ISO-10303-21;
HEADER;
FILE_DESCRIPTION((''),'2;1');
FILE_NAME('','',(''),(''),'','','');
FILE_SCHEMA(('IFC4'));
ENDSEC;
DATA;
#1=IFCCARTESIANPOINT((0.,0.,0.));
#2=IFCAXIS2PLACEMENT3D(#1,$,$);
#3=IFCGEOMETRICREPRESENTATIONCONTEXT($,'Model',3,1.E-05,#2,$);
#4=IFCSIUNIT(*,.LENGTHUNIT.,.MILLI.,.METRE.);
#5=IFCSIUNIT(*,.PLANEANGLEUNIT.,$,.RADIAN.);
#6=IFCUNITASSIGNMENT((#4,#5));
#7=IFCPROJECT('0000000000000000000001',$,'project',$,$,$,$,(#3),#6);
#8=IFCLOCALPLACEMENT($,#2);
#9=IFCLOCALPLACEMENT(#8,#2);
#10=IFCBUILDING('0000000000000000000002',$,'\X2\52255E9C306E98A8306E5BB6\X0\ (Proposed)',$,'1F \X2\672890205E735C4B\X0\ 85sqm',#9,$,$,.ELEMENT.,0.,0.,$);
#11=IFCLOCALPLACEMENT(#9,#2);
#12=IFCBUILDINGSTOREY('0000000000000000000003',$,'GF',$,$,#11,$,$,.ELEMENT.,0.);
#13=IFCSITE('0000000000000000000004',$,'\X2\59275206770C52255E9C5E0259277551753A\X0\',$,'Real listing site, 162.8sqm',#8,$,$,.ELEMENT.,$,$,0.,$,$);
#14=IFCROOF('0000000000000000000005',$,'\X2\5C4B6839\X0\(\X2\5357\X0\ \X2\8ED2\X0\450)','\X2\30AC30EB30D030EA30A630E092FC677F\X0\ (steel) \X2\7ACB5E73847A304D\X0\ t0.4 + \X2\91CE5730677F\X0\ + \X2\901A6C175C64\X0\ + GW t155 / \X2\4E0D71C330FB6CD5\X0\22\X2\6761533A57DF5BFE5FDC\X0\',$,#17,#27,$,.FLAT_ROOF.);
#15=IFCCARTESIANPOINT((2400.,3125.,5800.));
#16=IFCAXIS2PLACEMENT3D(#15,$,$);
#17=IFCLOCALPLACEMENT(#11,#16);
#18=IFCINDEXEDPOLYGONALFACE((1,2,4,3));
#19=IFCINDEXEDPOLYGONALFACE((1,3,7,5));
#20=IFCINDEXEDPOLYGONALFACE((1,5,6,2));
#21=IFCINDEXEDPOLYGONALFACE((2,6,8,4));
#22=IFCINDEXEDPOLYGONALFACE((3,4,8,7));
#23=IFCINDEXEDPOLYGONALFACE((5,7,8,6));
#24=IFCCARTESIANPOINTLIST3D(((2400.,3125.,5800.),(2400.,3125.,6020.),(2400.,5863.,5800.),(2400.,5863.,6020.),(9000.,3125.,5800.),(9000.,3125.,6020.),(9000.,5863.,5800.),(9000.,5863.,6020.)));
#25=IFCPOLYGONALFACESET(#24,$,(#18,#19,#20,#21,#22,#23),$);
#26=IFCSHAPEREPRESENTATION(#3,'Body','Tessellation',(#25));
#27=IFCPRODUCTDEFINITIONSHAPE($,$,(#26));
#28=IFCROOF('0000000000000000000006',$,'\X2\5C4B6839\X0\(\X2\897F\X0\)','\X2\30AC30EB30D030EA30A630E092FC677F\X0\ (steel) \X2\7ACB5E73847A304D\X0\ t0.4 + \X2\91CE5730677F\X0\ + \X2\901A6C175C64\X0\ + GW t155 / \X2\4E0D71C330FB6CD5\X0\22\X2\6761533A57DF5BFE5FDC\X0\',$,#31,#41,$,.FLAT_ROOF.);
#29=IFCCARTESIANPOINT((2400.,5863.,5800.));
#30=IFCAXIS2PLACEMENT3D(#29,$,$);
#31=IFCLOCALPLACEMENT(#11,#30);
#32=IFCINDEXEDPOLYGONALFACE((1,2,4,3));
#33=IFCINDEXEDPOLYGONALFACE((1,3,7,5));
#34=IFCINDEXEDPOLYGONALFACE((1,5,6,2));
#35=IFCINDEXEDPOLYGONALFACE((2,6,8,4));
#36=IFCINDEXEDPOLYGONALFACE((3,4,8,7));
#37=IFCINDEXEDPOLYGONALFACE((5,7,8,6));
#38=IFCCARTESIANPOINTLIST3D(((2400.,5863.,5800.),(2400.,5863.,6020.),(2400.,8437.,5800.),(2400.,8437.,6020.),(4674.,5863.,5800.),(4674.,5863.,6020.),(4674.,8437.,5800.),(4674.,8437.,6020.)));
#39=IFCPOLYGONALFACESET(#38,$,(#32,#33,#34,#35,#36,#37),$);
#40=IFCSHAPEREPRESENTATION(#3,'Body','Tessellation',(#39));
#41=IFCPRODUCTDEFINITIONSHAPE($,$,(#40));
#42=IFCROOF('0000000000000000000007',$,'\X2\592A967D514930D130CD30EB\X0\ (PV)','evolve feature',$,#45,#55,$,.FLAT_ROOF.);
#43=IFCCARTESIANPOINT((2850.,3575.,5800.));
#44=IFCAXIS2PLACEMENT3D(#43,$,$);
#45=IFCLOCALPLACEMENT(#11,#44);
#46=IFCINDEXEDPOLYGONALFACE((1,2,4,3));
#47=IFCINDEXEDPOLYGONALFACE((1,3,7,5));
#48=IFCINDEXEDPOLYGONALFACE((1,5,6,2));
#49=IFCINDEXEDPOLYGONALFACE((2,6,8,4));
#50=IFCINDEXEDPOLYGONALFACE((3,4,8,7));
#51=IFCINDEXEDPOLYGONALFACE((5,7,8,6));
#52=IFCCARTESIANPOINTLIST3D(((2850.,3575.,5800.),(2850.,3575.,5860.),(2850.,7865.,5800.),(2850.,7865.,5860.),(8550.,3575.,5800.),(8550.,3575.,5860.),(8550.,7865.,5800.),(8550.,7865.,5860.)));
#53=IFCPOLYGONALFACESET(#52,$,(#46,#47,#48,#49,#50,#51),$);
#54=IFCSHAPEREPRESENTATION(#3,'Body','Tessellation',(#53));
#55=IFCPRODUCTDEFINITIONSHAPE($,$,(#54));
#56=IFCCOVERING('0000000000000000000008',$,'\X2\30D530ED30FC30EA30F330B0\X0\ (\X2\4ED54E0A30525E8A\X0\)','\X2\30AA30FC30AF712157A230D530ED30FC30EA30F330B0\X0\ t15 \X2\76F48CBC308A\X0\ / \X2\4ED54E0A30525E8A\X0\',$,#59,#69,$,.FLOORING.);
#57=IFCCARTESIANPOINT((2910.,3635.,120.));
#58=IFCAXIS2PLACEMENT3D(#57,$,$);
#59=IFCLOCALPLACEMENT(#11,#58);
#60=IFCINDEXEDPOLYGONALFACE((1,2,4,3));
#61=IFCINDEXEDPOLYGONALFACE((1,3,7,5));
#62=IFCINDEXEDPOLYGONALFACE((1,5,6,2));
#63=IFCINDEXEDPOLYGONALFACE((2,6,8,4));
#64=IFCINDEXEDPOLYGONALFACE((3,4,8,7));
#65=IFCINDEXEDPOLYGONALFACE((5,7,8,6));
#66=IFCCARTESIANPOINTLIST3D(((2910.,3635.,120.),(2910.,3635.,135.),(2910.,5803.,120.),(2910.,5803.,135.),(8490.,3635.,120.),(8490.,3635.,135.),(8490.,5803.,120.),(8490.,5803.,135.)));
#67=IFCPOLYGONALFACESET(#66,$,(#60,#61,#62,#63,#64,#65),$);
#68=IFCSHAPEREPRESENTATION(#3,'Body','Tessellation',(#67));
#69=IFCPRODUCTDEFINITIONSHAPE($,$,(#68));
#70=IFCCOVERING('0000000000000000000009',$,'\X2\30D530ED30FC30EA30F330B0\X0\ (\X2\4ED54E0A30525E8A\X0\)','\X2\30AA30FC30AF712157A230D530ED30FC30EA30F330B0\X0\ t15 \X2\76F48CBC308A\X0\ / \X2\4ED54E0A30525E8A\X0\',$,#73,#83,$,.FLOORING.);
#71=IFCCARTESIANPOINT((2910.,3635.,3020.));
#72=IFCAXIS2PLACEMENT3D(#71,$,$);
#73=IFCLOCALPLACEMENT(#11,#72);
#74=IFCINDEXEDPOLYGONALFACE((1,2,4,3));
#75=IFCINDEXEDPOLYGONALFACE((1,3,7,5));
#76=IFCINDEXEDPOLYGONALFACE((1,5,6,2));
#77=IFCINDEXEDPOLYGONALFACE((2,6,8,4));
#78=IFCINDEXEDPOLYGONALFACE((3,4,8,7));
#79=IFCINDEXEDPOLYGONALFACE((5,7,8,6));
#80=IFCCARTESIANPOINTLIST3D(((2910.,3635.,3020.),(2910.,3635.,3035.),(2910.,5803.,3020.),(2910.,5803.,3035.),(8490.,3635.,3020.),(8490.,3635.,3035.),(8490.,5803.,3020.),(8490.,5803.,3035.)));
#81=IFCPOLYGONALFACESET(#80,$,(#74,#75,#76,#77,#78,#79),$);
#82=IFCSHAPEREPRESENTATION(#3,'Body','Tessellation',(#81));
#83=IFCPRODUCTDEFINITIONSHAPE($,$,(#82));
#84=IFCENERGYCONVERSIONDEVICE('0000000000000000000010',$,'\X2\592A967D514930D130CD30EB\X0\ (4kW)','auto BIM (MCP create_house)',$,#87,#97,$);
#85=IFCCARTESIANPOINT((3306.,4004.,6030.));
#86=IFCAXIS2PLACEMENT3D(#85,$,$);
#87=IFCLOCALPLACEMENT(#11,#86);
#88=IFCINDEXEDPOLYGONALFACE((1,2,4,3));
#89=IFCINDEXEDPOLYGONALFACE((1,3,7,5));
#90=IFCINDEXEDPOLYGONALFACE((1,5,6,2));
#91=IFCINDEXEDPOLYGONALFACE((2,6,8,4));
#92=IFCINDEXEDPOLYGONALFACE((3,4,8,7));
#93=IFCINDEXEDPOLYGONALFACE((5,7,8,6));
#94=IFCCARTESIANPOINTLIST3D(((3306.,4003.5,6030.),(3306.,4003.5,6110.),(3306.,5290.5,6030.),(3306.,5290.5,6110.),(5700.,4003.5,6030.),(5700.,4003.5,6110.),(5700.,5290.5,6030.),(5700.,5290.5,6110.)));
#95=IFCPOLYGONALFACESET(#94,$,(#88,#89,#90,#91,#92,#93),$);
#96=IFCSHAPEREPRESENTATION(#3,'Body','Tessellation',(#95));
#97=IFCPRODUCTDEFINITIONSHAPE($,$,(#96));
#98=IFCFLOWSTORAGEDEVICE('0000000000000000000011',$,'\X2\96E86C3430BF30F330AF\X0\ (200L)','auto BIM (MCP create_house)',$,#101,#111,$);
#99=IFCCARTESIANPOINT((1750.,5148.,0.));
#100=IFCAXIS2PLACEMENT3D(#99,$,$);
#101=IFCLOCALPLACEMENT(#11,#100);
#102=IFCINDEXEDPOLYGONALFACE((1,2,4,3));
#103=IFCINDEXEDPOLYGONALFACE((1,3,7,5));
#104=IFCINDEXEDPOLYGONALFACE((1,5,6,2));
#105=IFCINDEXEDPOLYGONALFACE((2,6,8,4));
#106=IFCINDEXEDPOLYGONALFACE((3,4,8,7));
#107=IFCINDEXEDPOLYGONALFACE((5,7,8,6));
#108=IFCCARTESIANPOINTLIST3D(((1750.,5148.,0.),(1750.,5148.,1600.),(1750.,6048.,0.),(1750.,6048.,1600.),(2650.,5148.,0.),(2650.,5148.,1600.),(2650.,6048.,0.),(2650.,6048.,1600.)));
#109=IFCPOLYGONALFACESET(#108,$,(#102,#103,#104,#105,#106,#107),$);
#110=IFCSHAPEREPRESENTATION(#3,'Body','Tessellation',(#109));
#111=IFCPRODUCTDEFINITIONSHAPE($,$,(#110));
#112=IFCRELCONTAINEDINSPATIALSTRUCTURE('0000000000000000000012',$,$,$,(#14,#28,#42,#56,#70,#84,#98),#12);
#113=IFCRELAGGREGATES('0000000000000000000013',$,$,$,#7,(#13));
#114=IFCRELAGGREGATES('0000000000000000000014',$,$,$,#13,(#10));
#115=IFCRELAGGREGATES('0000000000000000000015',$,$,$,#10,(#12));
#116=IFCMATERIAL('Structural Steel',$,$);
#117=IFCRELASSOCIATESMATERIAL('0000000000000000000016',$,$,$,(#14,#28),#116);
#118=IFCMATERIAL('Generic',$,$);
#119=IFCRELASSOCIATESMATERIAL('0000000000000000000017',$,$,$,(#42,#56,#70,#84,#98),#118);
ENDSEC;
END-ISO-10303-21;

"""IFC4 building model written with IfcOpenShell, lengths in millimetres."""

from ifc_helpers import new_model, si_unit, frame, frame_2d, origin, place, context, project, spatial, rectangle, extrude, material, element, save


model = new_model("IFC4")

# Units and contexts
model_context = context("Model", 3, precision=1e-05, world=origin())
ifc_project = project(units=[si_unit("LENGTHUNIT", "METRE", prefix="MILLI"), si_unit("PLANEANGLEUNIT", "RADIAN")], contexts=[model_context])

# Site, building, storey
site_placement = place(None, origin())
site = spatial("IfcSite", under=ifc_project, at=site_placement, Name="大分県別府市大畑町", ObjectType="Real listing site, 162.8sqm", CompositionType="ELEMENT", RefElevation=0.0)
building_placement = place(site_placement, origin())
building = spatial("IfcBuilding", under=site, at=building_placement, Name="別府の風の家 (Proposed)", ObjectType="1F 木造平屋 85sqm", CompositionType="ELEMENT", ElevationOfRefHeight=0.0, ElevationOfTerrain=0.0)
storey_placement = place(building_placement, origin())
storey = spatial("IfcBuildingStorey", under=building, at=storey_placement, Name="GF", CompositionType="ELEMENT", Elevation=0.0)

# Shared definitions
ifc_material_1 = material(Name="Generic")

# Roofs
ifc_material_2 = material(Name="Structural Steel")
roof_1_placement = place(storey_placement, frame((2400.0, 3125.0, 5800.0)))
element("IfcRoof", 1, at=roof_1_placement, inside=storey, material=ifc_material_2, Name="屋根(南 軒450)", Description="ガルバリウム鋼板 (steel) 立平葺き t0.4 + 野地板 + 通気層 + GW t155 / 不燃・法22条区域対応", PredefinedType="FLAT_ROOF", context=model_context, shape_type="SweptSolid", body=[
    extrude(rectangle(XDim=6600.0, YDim=2738.0, at=frame_2d((3300.0, 1369.0))), frame((2400.0, 3125.0, 5800.0)), (0.0, 0.0, 1.0), 220.0),
])
roof_2_placement = place(storey_placement, frame((2400.0, 5863.0, 5800.0)))
element("IfcRoof", 2, at=roof_2_placement, inside=storey, material=ifc_material_2, Name="屋根(西)", Description="ガルバリウム鋼板 (steel) 立平葺き t0.4 + 野地板 + 通気層 + GW t155 / 不燃・法22条区域対応", PredefinedType="FLAT_ROOF", context=model_context, shape_type="SweptSolid", body=[
    extrude(rectangle(XDim=2274.0, YDim=2574.0, at=frame_2d((1137.0, 1287.0))), frame((2400.0, 5863.0, 5800.0)), (0.0, 0.0, 1.0), 220.0),
])
roof_3_placement = place(storey_placement, frame((2850.0, 3575.0, 5800.0)))
element("IfcRoof", 3, at=roof_3_placement, inside=storey, material=ifc_material_1, Name="太陽光パネル (PV)", Description="evolve feature", PredefinedType="FLAT_ROOF", context=model_context, shape_type="SweptSolid", body=[
    extrude(rectangle(XDim=5700.0, YDim=4290.0, at=frame_2d((2850.0, 2145.0))), frame((2850.0, 3575.0, 5800.0)), (0.0, 0.0, 1.0), 60.0),
])

# Coverings
covering_1_placement = place(storey_placement, frame((2910.0, 3635.0, 120.0)))
element("IfcCovering", 4, at=covering_1_placement, inside=storey, material=ifc_material_1, Name="フローリング (仕上げ床)", Description="オーク無垢フローリング t15 直貼り / 仕上げ床", PredefinedType="FLOORING", context=model_context, shape_type="SweptSolid", body=[
    extrude(rectangle(XDim=5580.0, YDim=2168.0, at=frame_2d((2790.0, 1084.0))), frame((2910.0, 3635.0, 120.0)), (0.0, 0.0, 1.0), 15.0),
])
covering_2_placement = place(storey_placement, frame((2910.0, 3635.0, 3020.0)))
element("IfcCovering", 5, at=covering_2_placement, inside=storey, material=ifc_material_1, Name="フローリング (仕上げ床)", Description="オーク無垢フローリング t15 直貼り / 仕上げ床", PredefinedType="FLOORING", context=model_context, shape_type="SweptSolid", body=[
    extrude(rectangle(XDim=5580.0, YDim=2168.0, at=frame_2d((2790.0, 1084.0))), frame((2910.0, 3635.0, 3020.0)), (0.0, 0.0, 1.0), 15.0),
])

# Energy conversion device
energy_conversion_device_placement = place(storey_placement, frame((3306.0, 4004.0, 6030.0)))
element("IfcEnergyConversionDevice", 6, at=energy_conversion_device_placement, inside=storey, material=ifc_material_1, Name="太陽光パネル (4kW)", Description="auto BIM (MCP create_house)", context=model_context, shape_type="SweptSolid", body=[
    extrude(rectangle(XDim=2394.0, YDim=1287.0, at=frame_2d((1197.0, 643.0))), frame((3306.0, 4004.0, 6030.0)), (0.0, 0.0, 1.0), 80.0),
])

# Flow storage device
flow_storage_device_placement = place(storey_placement, frame((1750.0, 5148.0, 0.0)))
element("IfcFlowStorageDevice", 7, at=flow_storage_device_placement, inside=storey, material=ifc_material_1, Name="雨水タンク (200L)", Description="auto BIM (MCP create_house)", context=model_context, shape_type="SweptSolid", body=[
    extrude(rectangle(XDim=900.0, YDim=900.0, at=frame_2d((450.0, 450.0))), frame((1750.0, 5148.0, 0.0)), (0.0, 0.0, 1.0), 1600.0),
])

save(model, "model.ifc")
